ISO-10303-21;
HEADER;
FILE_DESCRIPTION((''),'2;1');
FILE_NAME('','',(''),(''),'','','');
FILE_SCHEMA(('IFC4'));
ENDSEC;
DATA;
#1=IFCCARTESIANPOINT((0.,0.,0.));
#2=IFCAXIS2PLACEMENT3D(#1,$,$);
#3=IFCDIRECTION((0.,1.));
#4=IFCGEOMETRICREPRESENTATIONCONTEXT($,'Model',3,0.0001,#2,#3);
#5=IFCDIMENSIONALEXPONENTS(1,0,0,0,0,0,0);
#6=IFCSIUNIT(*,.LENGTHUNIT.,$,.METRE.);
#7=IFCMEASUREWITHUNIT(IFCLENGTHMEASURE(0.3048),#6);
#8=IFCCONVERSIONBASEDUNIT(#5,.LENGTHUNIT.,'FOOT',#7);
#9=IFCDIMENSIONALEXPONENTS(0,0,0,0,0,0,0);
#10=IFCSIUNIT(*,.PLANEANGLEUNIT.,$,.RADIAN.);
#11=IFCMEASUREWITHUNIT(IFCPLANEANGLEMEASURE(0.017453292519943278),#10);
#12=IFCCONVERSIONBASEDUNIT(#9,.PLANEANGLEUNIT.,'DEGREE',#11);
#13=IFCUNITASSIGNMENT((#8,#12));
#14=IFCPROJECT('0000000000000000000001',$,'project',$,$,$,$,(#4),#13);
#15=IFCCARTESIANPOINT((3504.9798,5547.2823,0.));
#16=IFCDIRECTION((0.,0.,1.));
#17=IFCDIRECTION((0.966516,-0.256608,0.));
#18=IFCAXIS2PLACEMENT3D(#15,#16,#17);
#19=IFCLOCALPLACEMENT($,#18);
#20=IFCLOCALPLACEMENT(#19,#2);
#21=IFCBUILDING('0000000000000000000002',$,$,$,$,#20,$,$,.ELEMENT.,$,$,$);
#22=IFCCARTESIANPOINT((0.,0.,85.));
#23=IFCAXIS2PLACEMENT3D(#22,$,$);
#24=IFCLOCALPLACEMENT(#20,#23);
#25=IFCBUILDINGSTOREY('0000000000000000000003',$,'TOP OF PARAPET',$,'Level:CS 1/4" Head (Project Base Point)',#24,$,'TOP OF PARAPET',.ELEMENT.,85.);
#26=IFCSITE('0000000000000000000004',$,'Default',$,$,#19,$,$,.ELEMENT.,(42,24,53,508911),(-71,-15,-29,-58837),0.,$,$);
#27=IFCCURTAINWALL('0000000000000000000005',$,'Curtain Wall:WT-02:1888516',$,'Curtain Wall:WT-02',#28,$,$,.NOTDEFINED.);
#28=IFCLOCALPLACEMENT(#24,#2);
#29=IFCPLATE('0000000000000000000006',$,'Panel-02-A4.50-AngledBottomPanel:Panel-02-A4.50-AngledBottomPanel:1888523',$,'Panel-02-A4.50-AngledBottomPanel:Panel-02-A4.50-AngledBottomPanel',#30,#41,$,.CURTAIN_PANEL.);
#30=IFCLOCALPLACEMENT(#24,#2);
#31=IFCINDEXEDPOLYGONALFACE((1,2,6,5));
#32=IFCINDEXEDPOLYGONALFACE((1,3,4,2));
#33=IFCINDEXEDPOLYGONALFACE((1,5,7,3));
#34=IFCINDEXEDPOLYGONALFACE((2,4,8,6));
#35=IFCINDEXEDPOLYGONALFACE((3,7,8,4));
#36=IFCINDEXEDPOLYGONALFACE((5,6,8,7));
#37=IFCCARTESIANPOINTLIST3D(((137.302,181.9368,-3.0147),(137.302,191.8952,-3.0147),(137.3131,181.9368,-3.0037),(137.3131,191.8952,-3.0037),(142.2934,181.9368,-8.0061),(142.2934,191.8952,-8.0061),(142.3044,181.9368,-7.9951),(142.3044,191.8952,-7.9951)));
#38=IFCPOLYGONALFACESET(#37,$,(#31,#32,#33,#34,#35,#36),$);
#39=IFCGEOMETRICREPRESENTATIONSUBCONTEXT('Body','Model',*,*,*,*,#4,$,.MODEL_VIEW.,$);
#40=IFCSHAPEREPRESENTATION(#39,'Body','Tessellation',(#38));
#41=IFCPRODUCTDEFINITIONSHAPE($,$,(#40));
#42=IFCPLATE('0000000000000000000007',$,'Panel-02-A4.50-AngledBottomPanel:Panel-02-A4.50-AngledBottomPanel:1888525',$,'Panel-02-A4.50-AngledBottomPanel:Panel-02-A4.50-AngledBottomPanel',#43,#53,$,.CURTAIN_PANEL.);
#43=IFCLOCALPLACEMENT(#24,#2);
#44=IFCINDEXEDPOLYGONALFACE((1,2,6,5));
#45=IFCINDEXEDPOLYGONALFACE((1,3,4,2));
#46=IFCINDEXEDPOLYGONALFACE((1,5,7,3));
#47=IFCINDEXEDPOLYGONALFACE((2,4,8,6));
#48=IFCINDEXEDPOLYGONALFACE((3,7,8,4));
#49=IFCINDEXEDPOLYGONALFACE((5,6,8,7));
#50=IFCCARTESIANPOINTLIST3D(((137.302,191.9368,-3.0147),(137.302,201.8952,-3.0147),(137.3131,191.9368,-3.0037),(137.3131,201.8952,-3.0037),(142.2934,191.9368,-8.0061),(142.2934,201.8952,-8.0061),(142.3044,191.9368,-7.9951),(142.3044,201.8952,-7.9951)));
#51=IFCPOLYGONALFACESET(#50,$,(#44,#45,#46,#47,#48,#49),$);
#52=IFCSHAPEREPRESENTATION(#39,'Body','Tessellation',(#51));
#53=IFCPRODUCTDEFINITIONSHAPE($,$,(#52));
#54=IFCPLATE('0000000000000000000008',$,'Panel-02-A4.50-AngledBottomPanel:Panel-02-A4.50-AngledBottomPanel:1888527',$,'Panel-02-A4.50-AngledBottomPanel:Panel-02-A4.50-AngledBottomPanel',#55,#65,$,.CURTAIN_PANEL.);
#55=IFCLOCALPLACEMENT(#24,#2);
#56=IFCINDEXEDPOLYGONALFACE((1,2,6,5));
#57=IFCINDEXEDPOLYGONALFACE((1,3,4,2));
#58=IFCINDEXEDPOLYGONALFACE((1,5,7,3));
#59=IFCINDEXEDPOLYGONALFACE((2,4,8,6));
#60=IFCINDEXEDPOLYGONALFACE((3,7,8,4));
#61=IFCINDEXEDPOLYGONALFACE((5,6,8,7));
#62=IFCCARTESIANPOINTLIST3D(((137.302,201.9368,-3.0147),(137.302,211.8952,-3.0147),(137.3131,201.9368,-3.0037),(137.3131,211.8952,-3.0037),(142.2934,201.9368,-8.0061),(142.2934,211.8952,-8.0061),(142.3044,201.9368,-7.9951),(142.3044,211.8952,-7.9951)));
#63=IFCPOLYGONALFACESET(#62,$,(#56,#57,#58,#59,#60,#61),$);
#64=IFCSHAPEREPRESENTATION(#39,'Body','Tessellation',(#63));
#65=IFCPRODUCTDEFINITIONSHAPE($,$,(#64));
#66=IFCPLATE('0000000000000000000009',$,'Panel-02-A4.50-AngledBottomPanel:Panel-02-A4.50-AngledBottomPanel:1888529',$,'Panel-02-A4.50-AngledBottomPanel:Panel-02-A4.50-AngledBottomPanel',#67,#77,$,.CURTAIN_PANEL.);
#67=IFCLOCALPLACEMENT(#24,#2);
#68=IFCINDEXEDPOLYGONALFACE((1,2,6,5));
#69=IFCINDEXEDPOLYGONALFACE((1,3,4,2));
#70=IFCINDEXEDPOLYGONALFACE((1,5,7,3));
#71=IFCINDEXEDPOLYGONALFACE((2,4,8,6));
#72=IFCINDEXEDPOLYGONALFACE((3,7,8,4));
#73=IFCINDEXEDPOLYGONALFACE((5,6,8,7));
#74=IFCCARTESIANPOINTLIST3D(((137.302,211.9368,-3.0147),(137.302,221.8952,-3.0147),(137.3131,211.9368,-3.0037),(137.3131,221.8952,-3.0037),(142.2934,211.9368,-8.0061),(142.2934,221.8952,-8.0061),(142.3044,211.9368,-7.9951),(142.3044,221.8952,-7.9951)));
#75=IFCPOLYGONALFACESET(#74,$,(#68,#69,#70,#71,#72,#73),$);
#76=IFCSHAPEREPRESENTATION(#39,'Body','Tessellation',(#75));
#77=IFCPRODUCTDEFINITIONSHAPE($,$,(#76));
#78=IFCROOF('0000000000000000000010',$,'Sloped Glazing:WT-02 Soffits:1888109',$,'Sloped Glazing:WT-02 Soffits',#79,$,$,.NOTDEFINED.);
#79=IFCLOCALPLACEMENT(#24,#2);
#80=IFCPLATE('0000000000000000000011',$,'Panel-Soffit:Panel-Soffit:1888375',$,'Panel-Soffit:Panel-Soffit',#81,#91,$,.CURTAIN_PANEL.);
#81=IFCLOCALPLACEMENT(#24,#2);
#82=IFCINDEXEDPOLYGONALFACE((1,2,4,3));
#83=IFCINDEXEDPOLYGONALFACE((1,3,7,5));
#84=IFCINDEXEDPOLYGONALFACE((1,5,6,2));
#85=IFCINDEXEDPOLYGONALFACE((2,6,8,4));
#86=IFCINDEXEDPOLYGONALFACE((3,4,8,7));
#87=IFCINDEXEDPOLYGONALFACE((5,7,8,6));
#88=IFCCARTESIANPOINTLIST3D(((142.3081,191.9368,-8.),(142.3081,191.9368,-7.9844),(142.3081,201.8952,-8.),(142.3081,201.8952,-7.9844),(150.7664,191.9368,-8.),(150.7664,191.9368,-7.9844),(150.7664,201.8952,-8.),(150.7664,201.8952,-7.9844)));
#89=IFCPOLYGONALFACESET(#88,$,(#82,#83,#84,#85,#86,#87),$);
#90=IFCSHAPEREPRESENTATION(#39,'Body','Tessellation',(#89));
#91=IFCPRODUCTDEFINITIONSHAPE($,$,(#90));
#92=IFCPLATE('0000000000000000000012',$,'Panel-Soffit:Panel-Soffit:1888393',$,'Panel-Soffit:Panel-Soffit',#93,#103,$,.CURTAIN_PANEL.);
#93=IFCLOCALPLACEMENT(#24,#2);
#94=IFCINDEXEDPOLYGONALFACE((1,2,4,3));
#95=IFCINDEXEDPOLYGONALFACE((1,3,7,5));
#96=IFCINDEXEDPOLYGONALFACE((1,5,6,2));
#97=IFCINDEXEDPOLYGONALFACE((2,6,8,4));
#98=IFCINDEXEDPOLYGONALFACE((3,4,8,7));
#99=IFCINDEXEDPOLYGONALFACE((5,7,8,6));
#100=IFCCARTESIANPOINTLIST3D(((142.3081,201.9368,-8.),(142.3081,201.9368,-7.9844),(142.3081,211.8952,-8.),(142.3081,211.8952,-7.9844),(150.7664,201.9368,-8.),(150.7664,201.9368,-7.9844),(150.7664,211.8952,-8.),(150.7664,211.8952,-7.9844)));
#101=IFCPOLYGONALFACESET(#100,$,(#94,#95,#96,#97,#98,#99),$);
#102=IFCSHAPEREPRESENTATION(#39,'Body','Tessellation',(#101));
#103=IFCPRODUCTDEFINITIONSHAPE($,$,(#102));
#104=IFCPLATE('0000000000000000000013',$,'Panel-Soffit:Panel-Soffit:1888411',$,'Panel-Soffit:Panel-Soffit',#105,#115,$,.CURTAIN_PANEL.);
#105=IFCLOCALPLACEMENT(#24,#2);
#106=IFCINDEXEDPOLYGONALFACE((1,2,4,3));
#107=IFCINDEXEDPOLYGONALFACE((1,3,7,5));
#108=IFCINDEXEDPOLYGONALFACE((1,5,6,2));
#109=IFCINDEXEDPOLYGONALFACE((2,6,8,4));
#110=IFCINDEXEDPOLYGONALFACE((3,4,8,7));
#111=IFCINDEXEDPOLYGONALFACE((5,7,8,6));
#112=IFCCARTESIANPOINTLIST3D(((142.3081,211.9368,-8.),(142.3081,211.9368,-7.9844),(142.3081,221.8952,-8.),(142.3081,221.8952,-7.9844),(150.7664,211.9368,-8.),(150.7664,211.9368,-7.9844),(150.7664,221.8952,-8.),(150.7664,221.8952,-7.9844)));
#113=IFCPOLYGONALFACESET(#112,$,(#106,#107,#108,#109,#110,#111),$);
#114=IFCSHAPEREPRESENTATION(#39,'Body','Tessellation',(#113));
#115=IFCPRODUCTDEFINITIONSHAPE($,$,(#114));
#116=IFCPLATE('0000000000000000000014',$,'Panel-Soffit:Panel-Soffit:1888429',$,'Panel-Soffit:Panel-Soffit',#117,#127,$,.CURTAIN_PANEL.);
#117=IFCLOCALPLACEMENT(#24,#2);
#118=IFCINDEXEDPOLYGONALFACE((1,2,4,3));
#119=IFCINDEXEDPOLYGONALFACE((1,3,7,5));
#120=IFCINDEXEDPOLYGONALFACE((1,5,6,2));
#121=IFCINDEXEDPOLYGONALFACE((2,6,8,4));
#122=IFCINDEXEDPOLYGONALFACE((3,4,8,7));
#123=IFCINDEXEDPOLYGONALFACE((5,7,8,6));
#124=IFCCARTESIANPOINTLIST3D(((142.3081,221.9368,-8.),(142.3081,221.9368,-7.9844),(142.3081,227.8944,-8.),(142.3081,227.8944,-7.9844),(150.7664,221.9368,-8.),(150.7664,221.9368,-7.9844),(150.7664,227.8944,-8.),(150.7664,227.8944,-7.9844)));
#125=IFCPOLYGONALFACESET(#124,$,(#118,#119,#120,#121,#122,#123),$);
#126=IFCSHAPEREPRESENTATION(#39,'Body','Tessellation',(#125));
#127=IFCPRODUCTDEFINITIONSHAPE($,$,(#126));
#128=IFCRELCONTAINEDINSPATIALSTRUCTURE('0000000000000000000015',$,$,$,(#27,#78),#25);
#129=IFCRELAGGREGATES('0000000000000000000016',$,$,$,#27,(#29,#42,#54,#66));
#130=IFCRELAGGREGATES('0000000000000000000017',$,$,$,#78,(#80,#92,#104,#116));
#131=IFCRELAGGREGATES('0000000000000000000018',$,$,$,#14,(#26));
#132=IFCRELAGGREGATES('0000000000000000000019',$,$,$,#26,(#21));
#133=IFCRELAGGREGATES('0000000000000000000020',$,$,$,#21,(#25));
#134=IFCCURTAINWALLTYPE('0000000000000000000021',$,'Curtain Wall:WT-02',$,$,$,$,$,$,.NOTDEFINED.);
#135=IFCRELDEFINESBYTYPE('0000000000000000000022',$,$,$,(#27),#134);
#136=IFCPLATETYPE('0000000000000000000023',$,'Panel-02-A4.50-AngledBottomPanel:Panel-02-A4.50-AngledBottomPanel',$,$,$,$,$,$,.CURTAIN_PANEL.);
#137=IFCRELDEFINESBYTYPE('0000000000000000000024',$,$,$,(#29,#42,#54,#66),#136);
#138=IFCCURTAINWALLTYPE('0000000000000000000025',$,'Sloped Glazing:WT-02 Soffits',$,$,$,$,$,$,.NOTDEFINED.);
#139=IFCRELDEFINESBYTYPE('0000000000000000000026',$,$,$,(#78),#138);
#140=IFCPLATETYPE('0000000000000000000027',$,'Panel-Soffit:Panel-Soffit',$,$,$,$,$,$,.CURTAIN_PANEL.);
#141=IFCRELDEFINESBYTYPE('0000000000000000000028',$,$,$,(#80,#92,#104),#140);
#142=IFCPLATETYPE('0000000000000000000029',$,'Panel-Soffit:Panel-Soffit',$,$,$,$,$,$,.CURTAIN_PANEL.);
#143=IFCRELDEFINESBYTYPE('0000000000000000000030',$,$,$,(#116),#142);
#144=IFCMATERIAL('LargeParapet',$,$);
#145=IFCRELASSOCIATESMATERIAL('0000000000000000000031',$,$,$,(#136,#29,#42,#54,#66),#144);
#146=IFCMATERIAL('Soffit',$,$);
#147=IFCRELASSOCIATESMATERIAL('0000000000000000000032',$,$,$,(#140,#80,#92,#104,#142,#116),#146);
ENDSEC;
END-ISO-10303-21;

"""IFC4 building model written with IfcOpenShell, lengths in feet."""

from ifc_helpers import new_model, entity, si_unit, converted_unit, direction, frame, origin, place, context, subcontext, project, spatial, indexed_curve, outline, extrude, source, transform, mapped, material, type_object, type_shapes, element, aggregate, save


model = new_model("IFC4")

# Units and contexts
model_context = context("Model", 3, precision=0.0001, world=origin(), true_north=direction((0.0, 1.0)))
body_context = subcontext(model_context, "Body", "Model", "MODEL_VIEW")
ifc_project = project(units=[converted_unit("LENGTHUNIT", "FOOT", entity("IfcLengthMeasure", 0.3048), si_unit("LENGTHUNIT", "METRE"), dimensions=[1, 0, 0, 0, 0, 0, 0]), converted_unit("PLANEANGLEUNIT", "DEGREE", entity("IfcPlaneAngleMeasure", 0.017453292519943278), si_unit("PLANEANGLEUNIT", "RADIAN"), dimensions=[0, 0, 0, 0, 0, 0, 0])], contexts=[model_context])

# Site, building, storey
site_placement = place(None, frame((3504.9798, 5547.2823, 0.0), z_axis=(0.0, 0.0, 1.0), x_axis=(0.966516, -0.256608, 0.0)))
site = spatial("IfcSite", under=ifc_project, at=site_placement, Name="Default", CompositionType="ELEMENT", RefLatitude=(42, 24, 53, 508911), RefLongitude=(-71, -15, -29, -58837), RefElevation=0.0)
building_placement = place(site_placement, origin())
building = spatial("IfcBuilding", under=site, at=building_placement, CompositionType="ELEMENT")
storey_placement = place(building_placement, frame((0.0, 0.0, 85.0)))
storey = spatial("IfcBuildingStorey", under=building, at=storey_placement, Name="TOP OF PARAPET", ObjectType="Level:CS 1/4\" Head (Project Base Point)", LongName="TOP OF PARAPET", CompositionType="ELEMENT", Elevation=85.0)

# Curtain wall, plates
curtain_wall_type_1 = type_object("IfcCurtainWallType", Name="Curtain Wall:WT-02", PredefinedType="NOTDEFINED")
ifc_material_1 = material(Name="LargeParapet")
curtain_wall_1_placement = place(storey_placement, frame((0.0, 0.0, -85.0)))
curtain_wall_1 = element("IfcCurtainWall", 1, at=curtain_wall_1_placement, inside=storey, type_object=curtain_wall_type_1, Name="Curtain Wall:WT-02:1888516", ObjectType="Curtain Wall:WT-02", PredefinedType="NOTDEFINED")
plate_type_1 = type_object("IfcPlateType", Name="Panel-02-A4.50-AngledBottomPanel:Panel-02-A4.50-AngledBottomPanel", PredefinedType="CURTAIN_PANEL", material=ifc_material_1)
shared_shape_1 = source(origin(), body_context, "Body", "SweptSolid", [
    extrude(outline(indexed_curve([(-0.0078, -4.9792), (0.0078, -4.9792), (0.0078, 4.9792), (-0.0078, 4.9792), (-0.0078, -4.9792)], self_intersect=False)), frame((0.0, -0.0078, 0.0208), z_axis=(0.0, 0.0, 1.0), x_axis=(0.0, -1.0, 0.0)), (0.0, 0.0, 1.0), 7.0589),
])
type_shapes(plate_type_1, [shared_shape_1])
plate_1_placement = place(curtain_wall_1_placement, frame((142.3081, 186.916, 76.9792), z_axis=(-0.707107, 0.0, 0.707107), x_axis=(0.0, 1.0, 0.0)))
plate_1 = element("IfcPlate", 2, at=plate_1_placement, type_object=plate_type_1, material=ifc_material_1, Name="Panel-02-A4.50-AngledBottomPanel:Panel-02-A4.50-AngledBottomPanel:1888523", ObjectType="Panel-02-A4.50-AngledBottomPanel:Panel-02-A4.50-AngledBottomPanel", PredefinedType="CURTAIN_PANEL", context=body_context, shape_type="MappedRepresentation", body=[
    mapped(shared_shape_1, transform((0.0, 0.0, 0.0), scale=1.0)),
])
plate_2_placement = place(curtain_wall_1_placement, frame((142.3081, 196.916, 76.9792), z_axis=(-0.707107, 0.0, 0.707107), x_axis=(0.0, 1.0, 0.0)))
plate_2 = element("IfcPlate", 3, at=plate_2_placement, type_object=plate_type_1, material=ifc_material_1, Name="Panel-02-A4.50-AngledBottomPanel:Panel-02-A4.50-AngledBottomPanel:1888525", ObjectType="Panel-02-A4.50-AngledBottomPanel:Panel-02-A4.50-AngledBottomPanel", PredefinedType="CURTAIN_PANEL", context=body_context, shape_type="MappedRepresentation", body=[
    mapped(shared_shape_1, transform((0.0, 0.0, 0.0), scale=1.0)),
])
plate_3_placement = place(curtain_wall_1_placement, frame((142.3081, 206.916, 76.9792), z_axis=(-0.707107, 0.0, 0.707107), x_axis=(0.0, 1.0, 0.0)))
plate_3 = element("IfcPlate", 4, at=plate_3_placement, type_object=plate_type_1, material=ifc_material_1, Name="Panel-02-A4.50-AngledBottomPanel:Panel-02-A4.50-AngledBottomPanel:1888527", ObjectType="Panel-02-A4.50-AngledBottomPanel:Panel-02-A4.50-AngledBottomPanel", PredefinedType="CURTAIN_PANEL", context=body_context, shape_type="MappedRepresentation", body=[
    mapped(shared_shape_1, transform((0.0, 0.0, 0.0), scale=1.0)),
])
plate_4_placement = place(curtain_wall_1_placement, frame((142.3081, 216.916, 76.9792), z_axis=(-0.707107, 0.0, 0.707107), x_axis=(0.0, 1.0, 0.0)))
plate_4 = element("IfcPlate", 5, at=plate_4_placement, type_object=plate_type_1, material=ifc_material_1, Name="Panel-02-A4.50-AngledBottomPanel:Panel-02-A4.50-AngledBottomPanel:1888529", ObjectType="Panel-02-A4.50-AngledBottomPanel:Panel-02-A4.50-AngledBottomPanel", PredefinedType="CURTAIN_PANEL", context=body_context, shape_type="MappedRepresentation", body=[
    mapped(shared_shape_1, transform((0.0, 0.0, 0.0), scale=1.0)),
])
aggregate(curtain_wall_1, [plate_1, plate_2, plate_3, plate_4])

# Roof, plates
curtain_wall_type_2 = type_object("IfcCurtainWallType", Name="Sloped Glazing:WT-02 Soffits", PredefinedType="NOTDEFINED")
roof_placement = place(storey_placement, frame((0.0, 0.0, -85.0)))
roof = element("IfcRoof", 6, at=roof_placement, inside=storey, type_object=curtain_wall_type_2, Name="Sloped Glazing:WT-02 Soffits:1888109", ObjectType="Sloped Glazing:WT-02 Soffits", PredefinedType="NOTDEFINED")
ifc_material_2 = material(Name="Soffit")
plate_type_2 = type_object("IfcPlateType", Name="Panel-Soffit:Panel-Soffit", PredefinedType="CURTAIN_PANEL", material=ifc_material_2)
shared_shape_2 = source(origin(), body_context, "Body", "SweptSolid", [
    extrude(outline(indexed_curve([(-0.0078, -4.2292), (0.0078, -4.2292), (0.0078, 4.2292), (-0.0078, 4.2292), (-0.0078, -4.2292)], self_intersect=False)), frame((0.0, -0.0078, 0.0208), z_axis=(0.0, 0.0, 1.0), x_axis=(0.0, -1.0, 0.0)), (0.0, 0.0, 1.0), 9.9583),
])
type_shapes(plate_type_2, [shared_shape_2])
plate_5_placement = place(roof_placement, frame((146.5373, 191.916, 77.0), z_axis=(0.0, 1.0, 0.0), x_axis=(1.0, 0.0, 0.0)))
plate_5 = element("IfcPlate", 7, at=plate_5_placement, type_object=plate_type_2, material=ifc_material_2, Name="Panel-Soffit:Panel-Soffit:1888375", ObjectType="Panel-Soffit:Panel-Soffit", PredefinedType="CURTAIN_PANEL", context=body_context, shape_type="MappedRepresentation", body=[
    mapped(shared_shape_2, transform((0.0, 0.0, 0.0), scale=1.0)),
])
plate_6_placement = place(roof_placement, frame((146.5373, 201.916, 77.0), z_axis=(0.0, 1.0, 0.0), x_axis=(1.0, 0.0, 0.0)))
plate_6 = element("IfcPlate", 8, at=plate_6_placement, type_object=plate_type_2, material=ifc_material_2, Name="Panel-Soffit:Panel-Soffit:1888393", ObjectType="Panel-Soffit:Panel-Soffit", PredefinedType="CURTAIN_PANEL", context=body_context, shape_type="MappedRepresentation", body=[
    mapped(shared_shape_2, transform((0.0, 0.0, 0.0), scale=1.0)),
])
plate_7_placement = place(roof_placement, frame((146.5373, 211.916, 77.0), z_axis=(0.0, 1.0, 0.0), x_axis=(1.0, 0.0, 0.0)))
plate_7 = element("IfcPlate", 9, at=plate_7_placement, type_object=plate_type_2, material=ifc_material_2, Name="Panel-Soffit:Panel-Soffit:1888411", ObjectType="Panel-Soffit:Panel-Soffit", PredefinedType="CURTAIN_PANEL", context=body_context, shape_type="MappedRepresentation", body=[
    mapped(shared_shape_2, transform((0.0, 0.0, 0.0), scale=1.0)),
])
plate_type_3 = type_object("IfcPlateType", Name="Panel-Soffit:Panel-Soffit", PredefinedType="CURTAIN_PANEL", material=ifc_material_2)
shared_shape_3 = source(origin(), body_context, "Body", "SweptSolid", [
    extrude(outline(indexed_curve([(-0.0078, -4.2292), (0.0078, -4.2292), (0.0078, 4.2292), (-0.0078, 4.2292), (-0.0078, -4.2292)], self_intersect=False)), frame((0.0, -0.0078, 0.0208), z_axis=(0.0, 0.0, 1.0), x_axis=(0.0, -1.0, 0.0)), (0.0, 0.0, 1.0), 5.9576),
])
type_shapes(plate_type_3, [shared_shape_3])
plate_8_placement = place(roof_placement, frame((146.5373, 221.916, 77.0), z_axis=(0.0, 1.0, 0.0), x_axis=(1.0, 0.0, 0.0)))
plate_8 = element("IfcPlate", 10, at=plate_8_placement, type_object=plate_type_3, material=ifc_material_2, Name="Panel-Soffit:Panel-Soffit:1888429", ObjectType="Panel-Soffit:Panel-Soffit", PredefinedType="CURTAIN_PANEL", context=body_context, shape_type="MappedRepresentation", body=[
    mapped(shared_shape_3, transform((0.0, 0.0, 0.0), scale=1.0)),
])
aggregate(roof, [plate_5, plate_6, plate_7, plate_8])

save(model, "model.ifc")
